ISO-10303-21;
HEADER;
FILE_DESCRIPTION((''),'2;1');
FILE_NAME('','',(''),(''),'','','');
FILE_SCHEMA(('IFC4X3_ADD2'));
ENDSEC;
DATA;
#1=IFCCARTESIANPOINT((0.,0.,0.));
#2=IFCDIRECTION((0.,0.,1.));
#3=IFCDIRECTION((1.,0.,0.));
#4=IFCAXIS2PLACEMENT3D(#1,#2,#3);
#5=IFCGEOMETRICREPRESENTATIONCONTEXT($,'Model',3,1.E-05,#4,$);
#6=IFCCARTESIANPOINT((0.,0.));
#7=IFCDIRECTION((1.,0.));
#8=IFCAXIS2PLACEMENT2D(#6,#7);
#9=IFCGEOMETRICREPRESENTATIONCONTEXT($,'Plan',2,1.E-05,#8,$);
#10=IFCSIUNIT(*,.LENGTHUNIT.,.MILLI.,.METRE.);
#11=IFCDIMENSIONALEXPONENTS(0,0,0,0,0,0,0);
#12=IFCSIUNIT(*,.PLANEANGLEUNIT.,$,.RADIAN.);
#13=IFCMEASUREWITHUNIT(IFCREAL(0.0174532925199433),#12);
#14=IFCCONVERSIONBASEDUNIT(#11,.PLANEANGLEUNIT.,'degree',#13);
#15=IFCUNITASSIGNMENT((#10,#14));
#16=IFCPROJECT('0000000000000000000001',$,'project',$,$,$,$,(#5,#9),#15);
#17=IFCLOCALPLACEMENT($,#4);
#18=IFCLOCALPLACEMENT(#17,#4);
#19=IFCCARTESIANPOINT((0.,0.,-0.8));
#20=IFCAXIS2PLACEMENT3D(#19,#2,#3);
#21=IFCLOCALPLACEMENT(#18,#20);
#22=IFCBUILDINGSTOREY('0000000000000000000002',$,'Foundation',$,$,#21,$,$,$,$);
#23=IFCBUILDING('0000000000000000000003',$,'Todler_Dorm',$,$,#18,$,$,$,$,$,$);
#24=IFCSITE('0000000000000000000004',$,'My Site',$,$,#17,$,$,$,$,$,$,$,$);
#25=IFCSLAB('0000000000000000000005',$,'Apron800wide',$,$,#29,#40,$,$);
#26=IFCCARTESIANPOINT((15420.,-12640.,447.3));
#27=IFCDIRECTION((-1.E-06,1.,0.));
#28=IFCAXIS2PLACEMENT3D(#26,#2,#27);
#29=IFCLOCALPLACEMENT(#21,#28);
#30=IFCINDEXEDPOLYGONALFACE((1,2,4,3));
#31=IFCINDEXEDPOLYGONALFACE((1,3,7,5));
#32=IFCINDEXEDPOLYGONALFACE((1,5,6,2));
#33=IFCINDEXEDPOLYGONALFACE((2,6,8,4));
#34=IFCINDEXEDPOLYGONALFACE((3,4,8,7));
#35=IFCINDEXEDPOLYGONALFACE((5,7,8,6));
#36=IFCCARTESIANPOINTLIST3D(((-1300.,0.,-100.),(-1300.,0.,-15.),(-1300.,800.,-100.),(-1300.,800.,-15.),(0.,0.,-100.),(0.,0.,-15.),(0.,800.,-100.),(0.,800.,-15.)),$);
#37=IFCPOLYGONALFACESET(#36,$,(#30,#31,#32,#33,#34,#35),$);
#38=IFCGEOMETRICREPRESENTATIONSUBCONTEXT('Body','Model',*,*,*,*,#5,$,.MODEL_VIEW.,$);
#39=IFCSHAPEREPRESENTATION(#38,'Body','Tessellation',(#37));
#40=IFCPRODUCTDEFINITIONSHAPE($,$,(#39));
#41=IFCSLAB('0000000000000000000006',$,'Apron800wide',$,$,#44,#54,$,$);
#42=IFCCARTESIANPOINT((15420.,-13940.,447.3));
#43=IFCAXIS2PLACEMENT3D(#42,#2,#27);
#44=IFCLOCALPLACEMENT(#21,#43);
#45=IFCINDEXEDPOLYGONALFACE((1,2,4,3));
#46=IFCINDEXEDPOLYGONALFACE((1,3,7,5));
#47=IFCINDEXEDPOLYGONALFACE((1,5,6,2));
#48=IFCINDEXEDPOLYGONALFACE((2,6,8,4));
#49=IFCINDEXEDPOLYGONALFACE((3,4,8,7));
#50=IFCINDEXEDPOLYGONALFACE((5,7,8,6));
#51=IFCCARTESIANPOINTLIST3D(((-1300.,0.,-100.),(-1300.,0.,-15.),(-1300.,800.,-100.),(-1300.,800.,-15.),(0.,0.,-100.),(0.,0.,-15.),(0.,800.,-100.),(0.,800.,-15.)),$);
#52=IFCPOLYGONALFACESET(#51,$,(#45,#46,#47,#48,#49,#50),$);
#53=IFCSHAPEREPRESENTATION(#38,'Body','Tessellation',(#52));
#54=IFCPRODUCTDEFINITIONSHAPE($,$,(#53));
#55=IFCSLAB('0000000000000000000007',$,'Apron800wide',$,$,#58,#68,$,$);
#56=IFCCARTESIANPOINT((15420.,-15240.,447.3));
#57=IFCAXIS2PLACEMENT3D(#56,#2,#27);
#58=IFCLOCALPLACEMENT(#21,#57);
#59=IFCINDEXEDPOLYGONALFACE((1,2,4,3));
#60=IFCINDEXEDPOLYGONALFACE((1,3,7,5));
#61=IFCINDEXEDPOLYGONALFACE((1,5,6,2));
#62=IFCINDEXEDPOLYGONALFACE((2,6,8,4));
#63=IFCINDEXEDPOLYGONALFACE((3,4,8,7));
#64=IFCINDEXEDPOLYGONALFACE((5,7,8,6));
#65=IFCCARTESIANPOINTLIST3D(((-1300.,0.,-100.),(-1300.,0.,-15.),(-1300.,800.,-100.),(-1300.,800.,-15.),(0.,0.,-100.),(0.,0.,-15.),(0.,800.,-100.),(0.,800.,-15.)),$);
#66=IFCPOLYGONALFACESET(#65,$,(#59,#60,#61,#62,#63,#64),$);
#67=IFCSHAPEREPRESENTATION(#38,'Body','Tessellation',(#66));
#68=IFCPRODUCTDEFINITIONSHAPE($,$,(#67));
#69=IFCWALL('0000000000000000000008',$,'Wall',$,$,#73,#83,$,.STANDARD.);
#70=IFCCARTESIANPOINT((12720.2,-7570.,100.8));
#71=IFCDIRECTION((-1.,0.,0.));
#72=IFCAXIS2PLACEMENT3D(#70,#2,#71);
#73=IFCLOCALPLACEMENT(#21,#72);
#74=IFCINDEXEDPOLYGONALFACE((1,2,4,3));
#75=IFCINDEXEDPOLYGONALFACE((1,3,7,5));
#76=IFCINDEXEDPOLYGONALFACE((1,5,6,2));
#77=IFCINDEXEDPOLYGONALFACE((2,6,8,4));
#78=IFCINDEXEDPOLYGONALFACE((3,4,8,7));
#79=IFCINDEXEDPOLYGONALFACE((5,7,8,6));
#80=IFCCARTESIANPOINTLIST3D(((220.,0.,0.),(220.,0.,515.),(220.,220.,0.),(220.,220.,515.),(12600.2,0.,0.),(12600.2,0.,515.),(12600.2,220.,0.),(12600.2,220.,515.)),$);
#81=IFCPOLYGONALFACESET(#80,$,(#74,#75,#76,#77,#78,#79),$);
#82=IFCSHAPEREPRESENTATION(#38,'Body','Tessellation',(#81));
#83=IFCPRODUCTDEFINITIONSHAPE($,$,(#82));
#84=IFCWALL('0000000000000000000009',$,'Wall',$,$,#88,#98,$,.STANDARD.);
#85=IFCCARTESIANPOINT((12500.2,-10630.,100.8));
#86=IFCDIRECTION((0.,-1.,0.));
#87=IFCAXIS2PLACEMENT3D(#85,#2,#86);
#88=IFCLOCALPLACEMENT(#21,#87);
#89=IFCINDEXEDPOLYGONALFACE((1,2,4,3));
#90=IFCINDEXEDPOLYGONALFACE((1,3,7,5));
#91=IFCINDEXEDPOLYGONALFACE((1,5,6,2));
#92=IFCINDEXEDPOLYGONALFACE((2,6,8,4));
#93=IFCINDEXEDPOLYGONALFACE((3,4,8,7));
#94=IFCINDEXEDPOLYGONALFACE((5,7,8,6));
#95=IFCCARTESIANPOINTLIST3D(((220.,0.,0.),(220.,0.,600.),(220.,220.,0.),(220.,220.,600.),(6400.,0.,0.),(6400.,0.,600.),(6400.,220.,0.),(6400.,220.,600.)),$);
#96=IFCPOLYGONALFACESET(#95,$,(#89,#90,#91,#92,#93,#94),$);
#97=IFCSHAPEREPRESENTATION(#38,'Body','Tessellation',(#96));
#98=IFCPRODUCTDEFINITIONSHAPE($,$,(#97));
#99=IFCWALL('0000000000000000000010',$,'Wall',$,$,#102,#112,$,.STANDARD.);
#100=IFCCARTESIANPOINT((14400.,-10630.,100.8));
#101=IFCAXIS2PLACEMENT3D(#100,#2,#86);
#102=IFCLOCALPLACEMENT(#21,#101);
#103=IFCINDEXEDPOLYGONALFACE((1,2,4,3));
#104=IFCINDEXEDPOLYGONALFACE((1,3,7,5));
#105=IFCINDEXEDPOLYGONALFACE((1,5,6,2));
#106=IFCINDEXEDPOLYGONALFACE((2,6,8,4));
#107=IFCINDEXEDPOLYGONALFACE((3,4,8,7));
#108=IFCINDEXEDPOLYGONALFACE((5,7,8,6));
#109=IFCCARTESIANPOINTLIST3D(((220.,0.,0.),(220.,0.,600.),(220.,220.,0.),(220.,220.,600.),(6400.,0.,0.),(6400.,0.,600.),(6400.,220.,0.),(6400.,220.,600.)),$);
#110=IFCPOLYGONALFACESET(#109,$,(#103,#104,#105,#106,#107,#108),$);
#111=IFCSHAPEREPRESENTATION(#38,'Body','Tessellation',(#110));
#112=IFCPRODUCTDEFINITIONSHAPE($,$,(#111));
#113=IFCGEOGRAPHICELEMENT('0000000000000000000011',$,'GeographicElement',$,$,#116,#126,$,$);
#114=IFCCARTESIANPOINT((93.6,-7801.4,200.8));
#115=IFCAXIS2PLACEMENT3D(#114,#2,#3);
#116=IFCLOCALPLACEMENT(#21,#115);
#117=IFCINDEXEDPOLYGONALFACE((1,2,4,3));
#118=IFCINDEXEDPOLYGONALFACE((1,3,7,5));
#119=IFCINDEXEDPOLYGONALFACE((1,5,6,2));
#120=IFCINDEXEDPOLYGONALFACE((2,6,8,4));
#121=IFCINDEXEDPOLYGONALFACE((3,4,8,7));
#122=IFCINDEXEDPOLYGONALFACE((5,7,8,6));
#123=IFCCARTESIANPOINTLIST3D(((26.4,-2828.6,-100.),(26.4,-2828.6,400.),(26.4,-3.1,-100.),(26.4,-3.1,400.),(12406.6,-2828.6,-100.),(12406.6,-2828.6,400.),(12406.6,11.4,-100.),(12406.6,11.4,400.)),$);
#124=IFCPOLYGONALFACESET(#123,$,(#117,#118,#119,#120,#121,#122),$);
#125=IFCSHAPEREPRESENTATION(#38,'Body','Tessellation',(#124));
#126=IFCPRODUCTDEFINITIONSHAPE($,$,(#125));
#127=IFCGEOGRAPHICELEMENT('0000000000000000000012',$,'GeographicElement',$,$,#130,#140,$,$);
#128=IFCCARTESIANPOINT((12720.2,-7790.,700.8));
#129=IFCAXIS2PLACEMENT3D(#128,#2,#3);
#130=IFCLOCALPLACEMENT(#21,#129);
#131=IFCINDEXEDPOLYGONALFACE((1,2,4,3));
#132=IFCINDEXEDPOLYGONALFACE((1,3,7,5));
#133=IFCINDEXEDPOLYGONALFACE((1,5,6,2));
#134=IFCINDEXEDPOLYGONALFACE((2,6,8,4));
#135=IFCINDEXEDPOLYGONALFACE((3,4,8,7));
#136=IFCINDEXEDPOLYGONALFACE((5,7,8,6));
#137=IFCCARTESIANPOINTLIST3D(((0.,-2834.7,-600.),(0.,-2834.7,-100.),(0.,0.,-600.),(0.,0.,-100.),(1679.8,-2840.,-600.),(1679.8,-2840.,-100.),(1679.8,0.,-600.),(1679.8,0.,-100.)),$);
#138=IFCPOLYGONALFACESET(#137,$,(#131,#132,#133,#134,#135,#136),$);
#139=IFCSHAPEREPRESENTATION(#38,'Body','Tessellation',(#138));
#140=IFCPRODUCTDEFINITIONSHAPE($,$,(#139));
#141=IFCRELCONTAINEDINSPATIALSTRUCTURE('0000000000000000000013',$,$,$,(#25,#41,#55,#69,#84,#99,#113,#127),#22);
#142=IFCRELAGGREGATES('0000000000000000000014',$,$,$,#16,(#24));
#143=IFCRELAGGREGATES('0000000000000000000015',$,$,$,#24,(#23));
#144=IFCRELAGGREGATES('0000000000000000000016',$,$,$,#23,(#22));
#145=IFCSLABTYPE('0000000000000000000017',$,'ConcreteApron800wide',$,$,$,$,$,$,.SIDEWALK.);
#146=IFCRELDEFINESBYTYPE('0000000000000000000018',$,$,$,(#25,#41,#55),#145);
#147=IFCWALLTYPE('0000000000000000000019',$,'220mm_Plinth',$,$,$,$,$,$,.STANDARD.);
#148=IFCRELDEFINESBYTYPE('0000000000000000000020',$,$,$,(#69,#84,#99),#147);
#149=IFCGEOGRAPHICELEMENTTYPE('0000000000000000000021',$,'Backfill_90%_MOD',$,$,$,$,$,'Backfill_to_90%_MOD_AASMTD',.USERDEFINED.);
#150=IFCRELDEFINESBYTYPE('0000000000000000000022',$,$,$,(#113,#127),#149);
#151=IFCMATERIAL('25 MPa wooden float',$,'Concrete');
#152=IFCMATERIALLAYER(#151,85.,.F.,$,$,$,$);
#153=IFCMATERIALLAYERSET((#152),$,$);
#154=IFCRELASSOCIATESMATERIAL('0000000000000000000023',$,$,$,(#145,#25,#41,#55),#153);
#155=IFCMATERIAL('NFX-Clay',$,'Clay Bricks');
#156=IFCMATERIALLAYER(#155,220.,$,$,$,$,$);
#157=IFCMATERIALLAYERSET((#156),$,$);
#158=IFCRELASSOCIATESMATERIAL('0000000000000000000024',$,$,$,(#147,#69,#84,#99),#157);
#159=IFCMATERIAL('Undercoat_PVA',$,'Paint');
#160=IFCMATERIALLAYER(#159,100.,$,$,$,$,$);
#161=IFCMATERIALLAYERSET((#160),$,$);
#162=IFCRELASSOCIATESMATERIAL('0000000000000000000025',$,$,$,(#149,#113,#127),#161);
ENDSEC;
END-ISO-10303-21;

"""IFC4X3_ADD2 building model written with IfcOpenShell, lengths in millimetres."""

from ifc_helpers import new_model, entity, si_unit, converted_unit, frame, origin_with_axes, origin_2d_with_axis, place, context, subcontext, project, spatial, line, indexed_curve, outline, extrude, material, layer, layer_set, layer_usage, type_object, element, save


model = new_model("IFC4X3_ADD2")

# Units and contexts
model_context = context("Model", 3, precision=1e-05, world=origin_with_axes())
plan_context = context("Plan", 2, precision=1e-05, world=origin_2d_with_axis())
body_context = subcontext(model_context, "Body", "Model", "MODEL_VIEW")
ifc_project = project(units=[si_unit("LENGTHUNIT", "METRE", prefix="MILLI"), converted_unit("PLANEANGLEUNIT", "degree", entity("IfcReal", 0.0174532925199433), si_unit("PLANEANGLEUNIT", "RADIAN"), dimensions=[0, 0, 0, 0, 0, 0, 0])], contexts=[model_context, plan_context])

# Site, building, storey
site_placement = place(None, origin_with_axes())
site = spatial("IfcSite", under=ifc_project, at=site_placement, Name="My Site")
building_placement = place(site_placement, origin_with_axes())
building = spatial("IfcBuilding", under=site, at=building_placement, Name="Todler_Dorm")
storey_placement = place(building_placement, frame((0.0, 0.0, -0.8), z_axis=(0.0, 0.0, 1.0), x_axis=(1.0, 0.0, 0.0)))
storey = spatial("IfcBuildingStorey", under=building, at=storey_placement, Name="Foundation")

# Shared definitions
ifc_material_1 = material(Name="Undercoat_PVA", Category="Paint")

# Slabs
ifc_material_2 = material(Name="25 MPa wooden float", Category="Concrete")
ifc_layer_1 = layer(ifc_material_2, 85.0, ventilated=False)
ifc_layer_set_1 = layer_set([ifc_layer_1])
slab_type_1 = type_object("IfcSlabType", Name="ConcreteApron800wide", PredefinedType="SIDEWALK", material=ifc_layer_set_1)
ifc_layer_usage_1 = layer_usage(ifc_layer_set_1, "AXIS3", "POSITIVE", -100.0)
slab_1_placement = place(storey_placement, frame((15420.0, -12640.0, 447.3), z_axis=(0.0, 0.0, 1.0), x_axis=(-0.000001, 1.0, 0.0)))
element("IfcSlab", 1, at=slab_1_placement, inside=storey, type_object=slab_type_1, material=ifc_layer_usage_1, Name="Apron800wide", context=body_context, shape_type="SweptSolid", body=[
    extrude(outline(indexed_curve([(0.0, 0.0), (0.0, 800.0), (-1300.0, 800.0), (-1300.0, 0.0), (0.0, 0.0)])), frame((0.0, 0.0, -100.0), z_axis=(0.0, 0.0, 1.0), x_axis=(1.0, 0.0, 0.0)), (0.0, 0.0, 1.0), 85.0),
])
ifc_layer_usage_2 = layer_usage(ifc_layer_set_1, "AXIS3", "POSITIVE", -100.0)
slab_2_placement = place(storey_placement, frame((15420.0, -13940.0, 447.3), z_axis=(0.0, 0.0, 1.0), x_axis=(-0.000001, 1.0, 0.0)))
element("IfcSlab", 2, at=slab_2_placement, inside=storey, type_object=slab_type_1, material=ifc_layer_usage_2, Name="Apron800wide", context=body_context, shape_type="SweptSolid", body=[
    extrude(outline(indexed_curve([(0.0, 0.0), (0.0, 800.0), (-1300.0, 800.0), (-1300.0, 0.0), (0.0, 0.0)])), frame((0.0, 0.0, -100.0), z_axis=(0.0, 0.0, 1.0), x_axis=(1.0, 0.0, 0.0)), (0.0, 0.0, 1.0), 85.0),
])
ifc_layer_usage_3 = layer_usage(ifc_layer_set_1, "AXIS3", "POSITIVE", -100.0)
slab_3_placement = place(storey_placement, frame((15420.0, -15240.0, 447.3), z_axis=(0.0, 0.0, 1.0), x_axis=(-0.000001, 1.0, 0.0)))
element("IfcSlab", 3, at=slab_3_placement, inside=storey, type_object=slab_type_1, material=ifc_layer_usage_3, Name="Apron800wide", context=body_context, shape_type="SweptSolid", body=[
    extrude(outline(indexed_curve([(0.0, 0.0), (0.0, 800.0), (-1300.0, 800.0), (-1300.0, 0.0), (0.0, 0.0)])), frame((0.0, 0.0, -100.0), z_axis=(0.0, 0.0, 1.0), x_axis=(1.0, 0.0, 0.0)), (0.0, 0.0, 1.0), 85.0),
])

# Walls
ifc_material_3 = material(Name="NFX-Clay", Category="Clay Bricks")
ifc_layer_2 = layer(ifc_material_3, 220.0)
ifc_layer_set_2 = layer_set([ifc_layer_2])
wall_type = type_object("IfcWallType", Name="220mm_Plinth", PredefinedType="STANDARD", material=ifc_layer_set_2)
ifc_layer_usage_4 = layer_usage(ifc_layer_set_2, "AXIS2", "POSITIVE", 0.0)
wall_1_placement = place(storey_placement, frame((12720.2, -7570.0, 100.8), z_axis=(0.0, 0.0, 1.0), x_axis=(-1.0, 0.0, 0.0)))
element("IfcWall", 4, at=wall_1_placement, inside=storey, type_object=wall_type, material=ifc_layer_usage_4, Name="Wall", PredefinedType="STANDARD", context=body_context, shape_type="SweptSolid", body=[
    extrude(outline(indexed_curve([(220.0, 0.0), (220.0, 220.0), (12600.2, 220.0), (12600.2, 0.0)], segments=[line(1, 2, 3, 4, 1)])), origin_with_axes(), (0.0, 0.0, 1.0), 515.0),
])
ifc_layer_usage_5 = layer_usage(ifc_layer_set_2, "AXIS2", "POSITIVE", 0.0)
wall_2_placement = place(storey_placement, frame((12500.2, -10630.0, 100.8), z_axis=(0.0, 0.0, 1.0), x_axis=(0.0, -1.0, 0.0)))
element("IfcWall", 5, at=wall_2_placement, inside=storey, type_object=wall_type, material=ifc_layer_usage_5, Name="Wall", PredefinedType="STANDARD", context=body_context, shape_type="SweptSolid", body=[
    extrude(outline(indexed_curve([(220.0, 0.0), (220.0, 220.0), (6400.0, 220.0), (6400.0, 0.0)], segments=[line(1, 2, 3, 4, 1)])), origin_with_axes(), (0.0, 0.0, 1.0), 600.0),
])
ifc_layer_usage_6 = layer_usage(ifc_layer_set_2, "AXIS2", "POSITIVE", 0.0)
wall_3_placement = place(storey_placement, frame((14400.0, -10630.0, 100.8), z_axis=(0.0, 0.0, 1.0), x_axis=(0.0, -1.0, 0.0)))
element("IfcWall", 6, at=wall_3_placement, inside=storey, type_object=wall_type, material=ifc_layer_usage_6, Name="Wall", PredefinedType="STANDARD", context=body_context, shape_type="SweptSolid", body=[
    extrude(outline(indexed_curve([(220.0, 0.0), (220.0, 220.0), (6400.0, 220.0), (6400.0, 0.0)], segments=[line(1, 2, 3, 4, 1)])), origin_with_axes(), (0.0, 0.0, 1.0), 600.0),
])

# Geographic elements
ifc_layer_3 = layer(ifc_material_1, 100.0)
ifc_layer_set_3 = layer_set([ifc_layer_3])
ifc_layer_usage_7 = layer_usage(ifc_layer_set_3, "AXIS3", "POSITIVE", -100.0)
geographic_element_type = type_object("IfcGeographicElementType", Name="Backfill_90%_MOD", ElementType="Backfill_to_90%_MOD_AASMTD", PredefinedType="USERDEFINED", material=ifc_layer_set_3)
geographic_element_1_placement = place(storey_placement, frame((93.6, -7801.4, 200.8), z_axis=(0.0, 0.0, 1.0), x_axis=(1.0, 0.0, 0.0)))
element("IfcGeographicElement", 7, at=geographic_element_1_placement, inside=storey, type_object=geographic_element_type, material=ifc_layer_usage_7, Name="GeographicElement", context=body_context, shape_type="SweptSolid", body=[
    extrude(outline(indexed_curve([(26.4, -2828.6), (12406.6, -2828.6), (12406.6, 11.4), (26.4, -3.1), (26.4, -2828.6)])), frame((0.0, 0.0, -100.0), z_axis=(0.0, 0.0, 1.0), x_axis=(1.0, 0.0, 0.0)), (0.0, 0.0, 1.0), 500.0),
])
ifc_layer_usage_8 = layer_usage(ifc_layer_set_3, "AXIS3", "POSITIVE", -100.0)
geographic_element_2_placement = place(storey_placement, frame((12720.2, -7790.0, 700.8), z_axis=(0.0, 0.0, 1.0), x_axis=(1.0, 0.0, 0.0)))
element("IfcGeographicElement", 8, at=geographic_element_2_placement, inside=storey, type_object=geographic_element_type, material=ifc_layer_usage_8, Name="GeographicElement", context=body_context, shape_type="SweptSolid", body=[
    extrude(outline(indexed_curve([(0.0, 0.0), (1679.8, 0.0), (1679.8, -2840.0), (0.0, -2834.7), (0.0, 0.0)])), frame((0.0, 0.0, -600.0), z_axis=(0.0, 0.0, 1.0), x_axis=(1.0, 0.0, 0.0)), (0.0, 0.0, 1.0), 500.0),
])

save(model, "model.ifc")
